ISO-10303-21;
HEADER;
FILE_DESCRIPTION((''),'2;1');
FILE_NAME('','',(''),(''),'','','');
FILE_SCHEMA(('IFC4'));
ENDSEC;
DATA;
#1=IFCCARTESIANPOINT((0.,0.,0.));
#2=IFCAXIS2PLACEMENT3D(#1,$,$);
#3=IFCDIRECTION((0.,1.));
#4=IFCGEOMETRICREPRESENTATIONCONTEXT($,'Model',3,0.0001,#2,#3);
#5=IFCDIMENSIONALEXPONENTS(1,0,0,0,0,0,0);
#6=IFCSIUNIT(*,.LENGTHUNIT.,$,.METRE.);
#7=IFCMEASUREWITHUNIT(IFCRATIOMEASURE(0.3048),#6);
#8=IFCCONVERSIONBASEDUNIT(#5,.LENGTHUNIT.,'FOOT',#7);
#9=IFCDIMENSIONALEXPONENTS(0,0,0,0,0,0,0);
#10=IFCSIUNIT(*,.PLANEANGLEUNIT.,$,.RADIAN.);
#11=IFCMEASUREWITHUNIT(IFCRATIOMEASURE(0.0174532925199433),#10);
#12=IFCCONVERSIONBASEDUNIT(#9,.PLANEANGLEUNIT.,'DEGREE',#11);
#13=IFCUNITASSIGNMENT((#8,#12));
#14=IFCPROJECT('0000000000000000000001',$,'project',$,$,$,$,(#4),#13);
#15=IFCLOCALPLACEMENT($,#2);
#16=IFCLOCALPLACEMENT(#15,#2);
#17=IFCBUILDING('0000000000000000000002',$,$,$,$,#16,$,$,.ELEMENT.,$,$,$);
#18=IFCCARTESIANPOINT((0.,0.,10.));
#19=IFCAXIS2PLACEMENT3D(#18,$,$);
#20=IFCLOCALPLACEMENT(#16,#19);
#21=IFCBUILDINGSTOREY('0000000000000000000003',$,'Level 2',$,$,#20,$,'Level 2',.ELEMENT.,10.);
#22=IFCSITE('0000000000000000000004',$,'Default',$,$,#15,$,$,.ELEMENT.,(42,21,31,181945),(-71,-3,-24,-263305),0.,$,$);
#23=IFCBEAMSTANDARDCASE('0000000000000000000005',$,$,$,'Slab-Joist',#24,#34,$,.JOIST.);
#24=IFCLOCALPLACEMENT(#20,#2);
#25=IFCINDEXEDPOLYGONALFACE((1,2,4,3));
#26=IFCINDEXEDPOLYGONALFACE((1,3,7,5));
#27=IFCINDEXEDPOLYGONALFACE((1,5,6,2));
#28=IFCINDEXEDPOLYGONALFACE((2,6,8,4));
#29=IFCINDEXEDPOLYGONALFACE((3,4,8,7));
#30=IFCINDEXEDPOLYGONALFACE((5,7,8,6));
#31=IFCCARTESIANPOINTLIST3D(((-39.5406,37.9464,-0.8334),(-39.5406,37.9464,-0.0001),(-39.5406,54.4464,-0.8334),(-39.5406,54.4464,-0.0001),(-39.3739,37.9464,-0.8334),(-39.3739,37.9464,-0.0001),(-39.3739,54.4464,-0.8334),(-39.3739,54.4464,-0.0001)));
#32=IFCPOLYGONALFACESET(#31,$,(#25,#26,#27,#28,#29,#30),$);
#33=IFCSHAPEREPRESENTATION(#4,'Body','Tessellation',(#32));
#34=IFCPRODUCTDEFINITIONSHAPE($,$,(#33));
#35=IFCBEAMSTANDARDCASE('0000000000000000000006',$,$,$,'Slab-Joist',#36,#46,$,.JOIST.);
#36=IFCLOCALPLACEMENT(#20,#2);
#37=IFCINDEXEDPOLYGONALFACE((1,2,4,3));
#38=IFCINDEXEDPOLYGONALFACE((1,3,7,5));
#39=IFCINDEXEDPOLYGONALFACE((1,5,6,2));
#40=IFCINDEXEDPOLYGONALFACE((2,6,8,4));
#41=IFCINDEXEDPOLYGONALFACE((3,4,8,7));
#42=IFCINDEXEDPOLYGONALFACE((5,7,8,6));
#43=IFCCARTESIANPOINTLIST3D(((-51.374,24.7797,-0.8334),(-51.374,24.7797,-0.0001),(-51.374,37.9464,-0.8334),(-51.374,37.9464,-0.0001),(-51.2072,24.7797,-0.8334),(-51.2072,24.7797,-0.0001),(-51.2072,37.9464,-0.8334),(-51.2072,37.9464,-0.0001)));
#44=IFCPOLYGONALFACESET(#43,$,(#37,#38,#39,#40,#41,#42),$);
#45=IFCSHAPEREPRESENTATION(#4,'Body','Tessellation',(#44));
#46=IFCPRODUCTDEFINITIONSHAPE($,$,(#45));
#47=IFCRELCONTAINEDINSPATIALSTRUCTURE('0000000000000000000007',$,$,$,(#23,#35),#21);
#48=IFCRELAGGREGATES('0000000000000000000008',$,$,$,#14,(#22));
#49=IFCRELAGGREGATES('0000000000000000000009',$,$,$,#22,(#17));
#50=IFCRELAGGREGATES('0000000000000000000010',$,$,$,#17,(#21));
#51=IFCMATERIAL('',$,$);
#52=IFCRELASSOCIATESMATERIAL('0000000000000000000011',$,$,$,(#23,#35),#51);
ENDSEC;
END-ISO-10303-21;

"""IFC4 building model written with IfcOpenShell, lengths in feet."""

from ifc_helpers import new_model, entity, si_unit, converted_unit, direction, frame, origin, origin_with_axes, place, context, project, spatial, rectangle, extrude, material, element, save


model = new_model("IFC4")

# Units and contexts
model_context = context("Model", 3, precision=0.0001, world=origin(), true_north=direction((0.0, 1.0)))
ifc_project = project(units=[converted_unit("LENGTHUNIT", "FOOT", entity("IfcRatioMeasure", 0.3048), si_unit("LENGTHUNIT", "METRE"), dimensions=[1, 0, 0, 0, 0, 0, 0]), converted_unit("PLANEANGLEUNIT", "DEGREE", entity("IfcRatioMeasure", 0.0174532925199433), si_unit("PLANEANGLEUNIT", "RADIAN"), dimensions=[0, 0, 0, 0, 0, 0, 0])], contexts=[model_context])

# Site, building, storey
site_placement = place(None, origin())
site = spatial("IfcSite", under=ifc_project, at=site_placement, Name="Default", CompositionType="ELEMENT", RefLatitude=(42, 21, 31, 181945), RefLongitude=(-71, -3, -24, -263305), RefElevation=0.0)
building_placement = place(site_placement, origin())
building = spatial("IfcBuilding", under=site, at=building_placement, CompositionType="ELEMENT")
storey_placement = place(building_placement, frame((0.0, 0.0, 10.0)))
storey = spatial("IfcBuildingStorey", under=building, at=storey_placement, Name="Level 2", LongName="Level 2", CompositionType="ELEMENT", Elevation=10.0)

# Beams
ifc_material = material(Name="")
placement_1 = place(storey_placement, frame((-39.4573, 37.9464, 0.0), z_axis=(0.0, 0.0, 1.0), x_axis=(1.0, 0.0, 0.0)))
beam_1_placement = place(placement_1, frame((0.0, 0.0, -0.4167), z_axis=(0.0, 1.0, 0.0), x_axis=(-1.0, 0.0, 0.0)))
element("IfcBeamStandardCase", 1, at=beam_1_placement, inside=storey, material=ifc_material, ObjectType="Slab-Joist", PredefinedType="JOIST", context=model_context, shape_type="SweptSolid", body=[
    extrude(rectangle(XDim=0.1667, YDim=0.8333), origin_with_axes(), (0.0, 0.0, 1.0), 16.5),
])
placement_2 = place(storey_placement, frame((-51.2906, 24.7797, 0.0), z_axis=(0.0, 0.0, 1.0), x_axis=(1.0, 0.0, 0.0)))
beam_2_placement = place(placement_2, frame((0.0, 0.0, -0.4167), z_axis=(0.0, 1.0, 0.0), x_axis=(-1.0, 0.0, 0.0)))
element("IfcBeamStandardCase", 2, at=beam_2_placement, inside=storey, material=ifc_material, ObjectType="Slab-Joist", PredefinedType="JOIST", context=model_context, shape_type="SweptSolid", body=[
    extrude(rectangle(XDim=0.1667, YDim=0.8333), origin_with_axes(), (0.0, 0.0, 1.0), 13.1667),
])

save(model, "model.ifc")
